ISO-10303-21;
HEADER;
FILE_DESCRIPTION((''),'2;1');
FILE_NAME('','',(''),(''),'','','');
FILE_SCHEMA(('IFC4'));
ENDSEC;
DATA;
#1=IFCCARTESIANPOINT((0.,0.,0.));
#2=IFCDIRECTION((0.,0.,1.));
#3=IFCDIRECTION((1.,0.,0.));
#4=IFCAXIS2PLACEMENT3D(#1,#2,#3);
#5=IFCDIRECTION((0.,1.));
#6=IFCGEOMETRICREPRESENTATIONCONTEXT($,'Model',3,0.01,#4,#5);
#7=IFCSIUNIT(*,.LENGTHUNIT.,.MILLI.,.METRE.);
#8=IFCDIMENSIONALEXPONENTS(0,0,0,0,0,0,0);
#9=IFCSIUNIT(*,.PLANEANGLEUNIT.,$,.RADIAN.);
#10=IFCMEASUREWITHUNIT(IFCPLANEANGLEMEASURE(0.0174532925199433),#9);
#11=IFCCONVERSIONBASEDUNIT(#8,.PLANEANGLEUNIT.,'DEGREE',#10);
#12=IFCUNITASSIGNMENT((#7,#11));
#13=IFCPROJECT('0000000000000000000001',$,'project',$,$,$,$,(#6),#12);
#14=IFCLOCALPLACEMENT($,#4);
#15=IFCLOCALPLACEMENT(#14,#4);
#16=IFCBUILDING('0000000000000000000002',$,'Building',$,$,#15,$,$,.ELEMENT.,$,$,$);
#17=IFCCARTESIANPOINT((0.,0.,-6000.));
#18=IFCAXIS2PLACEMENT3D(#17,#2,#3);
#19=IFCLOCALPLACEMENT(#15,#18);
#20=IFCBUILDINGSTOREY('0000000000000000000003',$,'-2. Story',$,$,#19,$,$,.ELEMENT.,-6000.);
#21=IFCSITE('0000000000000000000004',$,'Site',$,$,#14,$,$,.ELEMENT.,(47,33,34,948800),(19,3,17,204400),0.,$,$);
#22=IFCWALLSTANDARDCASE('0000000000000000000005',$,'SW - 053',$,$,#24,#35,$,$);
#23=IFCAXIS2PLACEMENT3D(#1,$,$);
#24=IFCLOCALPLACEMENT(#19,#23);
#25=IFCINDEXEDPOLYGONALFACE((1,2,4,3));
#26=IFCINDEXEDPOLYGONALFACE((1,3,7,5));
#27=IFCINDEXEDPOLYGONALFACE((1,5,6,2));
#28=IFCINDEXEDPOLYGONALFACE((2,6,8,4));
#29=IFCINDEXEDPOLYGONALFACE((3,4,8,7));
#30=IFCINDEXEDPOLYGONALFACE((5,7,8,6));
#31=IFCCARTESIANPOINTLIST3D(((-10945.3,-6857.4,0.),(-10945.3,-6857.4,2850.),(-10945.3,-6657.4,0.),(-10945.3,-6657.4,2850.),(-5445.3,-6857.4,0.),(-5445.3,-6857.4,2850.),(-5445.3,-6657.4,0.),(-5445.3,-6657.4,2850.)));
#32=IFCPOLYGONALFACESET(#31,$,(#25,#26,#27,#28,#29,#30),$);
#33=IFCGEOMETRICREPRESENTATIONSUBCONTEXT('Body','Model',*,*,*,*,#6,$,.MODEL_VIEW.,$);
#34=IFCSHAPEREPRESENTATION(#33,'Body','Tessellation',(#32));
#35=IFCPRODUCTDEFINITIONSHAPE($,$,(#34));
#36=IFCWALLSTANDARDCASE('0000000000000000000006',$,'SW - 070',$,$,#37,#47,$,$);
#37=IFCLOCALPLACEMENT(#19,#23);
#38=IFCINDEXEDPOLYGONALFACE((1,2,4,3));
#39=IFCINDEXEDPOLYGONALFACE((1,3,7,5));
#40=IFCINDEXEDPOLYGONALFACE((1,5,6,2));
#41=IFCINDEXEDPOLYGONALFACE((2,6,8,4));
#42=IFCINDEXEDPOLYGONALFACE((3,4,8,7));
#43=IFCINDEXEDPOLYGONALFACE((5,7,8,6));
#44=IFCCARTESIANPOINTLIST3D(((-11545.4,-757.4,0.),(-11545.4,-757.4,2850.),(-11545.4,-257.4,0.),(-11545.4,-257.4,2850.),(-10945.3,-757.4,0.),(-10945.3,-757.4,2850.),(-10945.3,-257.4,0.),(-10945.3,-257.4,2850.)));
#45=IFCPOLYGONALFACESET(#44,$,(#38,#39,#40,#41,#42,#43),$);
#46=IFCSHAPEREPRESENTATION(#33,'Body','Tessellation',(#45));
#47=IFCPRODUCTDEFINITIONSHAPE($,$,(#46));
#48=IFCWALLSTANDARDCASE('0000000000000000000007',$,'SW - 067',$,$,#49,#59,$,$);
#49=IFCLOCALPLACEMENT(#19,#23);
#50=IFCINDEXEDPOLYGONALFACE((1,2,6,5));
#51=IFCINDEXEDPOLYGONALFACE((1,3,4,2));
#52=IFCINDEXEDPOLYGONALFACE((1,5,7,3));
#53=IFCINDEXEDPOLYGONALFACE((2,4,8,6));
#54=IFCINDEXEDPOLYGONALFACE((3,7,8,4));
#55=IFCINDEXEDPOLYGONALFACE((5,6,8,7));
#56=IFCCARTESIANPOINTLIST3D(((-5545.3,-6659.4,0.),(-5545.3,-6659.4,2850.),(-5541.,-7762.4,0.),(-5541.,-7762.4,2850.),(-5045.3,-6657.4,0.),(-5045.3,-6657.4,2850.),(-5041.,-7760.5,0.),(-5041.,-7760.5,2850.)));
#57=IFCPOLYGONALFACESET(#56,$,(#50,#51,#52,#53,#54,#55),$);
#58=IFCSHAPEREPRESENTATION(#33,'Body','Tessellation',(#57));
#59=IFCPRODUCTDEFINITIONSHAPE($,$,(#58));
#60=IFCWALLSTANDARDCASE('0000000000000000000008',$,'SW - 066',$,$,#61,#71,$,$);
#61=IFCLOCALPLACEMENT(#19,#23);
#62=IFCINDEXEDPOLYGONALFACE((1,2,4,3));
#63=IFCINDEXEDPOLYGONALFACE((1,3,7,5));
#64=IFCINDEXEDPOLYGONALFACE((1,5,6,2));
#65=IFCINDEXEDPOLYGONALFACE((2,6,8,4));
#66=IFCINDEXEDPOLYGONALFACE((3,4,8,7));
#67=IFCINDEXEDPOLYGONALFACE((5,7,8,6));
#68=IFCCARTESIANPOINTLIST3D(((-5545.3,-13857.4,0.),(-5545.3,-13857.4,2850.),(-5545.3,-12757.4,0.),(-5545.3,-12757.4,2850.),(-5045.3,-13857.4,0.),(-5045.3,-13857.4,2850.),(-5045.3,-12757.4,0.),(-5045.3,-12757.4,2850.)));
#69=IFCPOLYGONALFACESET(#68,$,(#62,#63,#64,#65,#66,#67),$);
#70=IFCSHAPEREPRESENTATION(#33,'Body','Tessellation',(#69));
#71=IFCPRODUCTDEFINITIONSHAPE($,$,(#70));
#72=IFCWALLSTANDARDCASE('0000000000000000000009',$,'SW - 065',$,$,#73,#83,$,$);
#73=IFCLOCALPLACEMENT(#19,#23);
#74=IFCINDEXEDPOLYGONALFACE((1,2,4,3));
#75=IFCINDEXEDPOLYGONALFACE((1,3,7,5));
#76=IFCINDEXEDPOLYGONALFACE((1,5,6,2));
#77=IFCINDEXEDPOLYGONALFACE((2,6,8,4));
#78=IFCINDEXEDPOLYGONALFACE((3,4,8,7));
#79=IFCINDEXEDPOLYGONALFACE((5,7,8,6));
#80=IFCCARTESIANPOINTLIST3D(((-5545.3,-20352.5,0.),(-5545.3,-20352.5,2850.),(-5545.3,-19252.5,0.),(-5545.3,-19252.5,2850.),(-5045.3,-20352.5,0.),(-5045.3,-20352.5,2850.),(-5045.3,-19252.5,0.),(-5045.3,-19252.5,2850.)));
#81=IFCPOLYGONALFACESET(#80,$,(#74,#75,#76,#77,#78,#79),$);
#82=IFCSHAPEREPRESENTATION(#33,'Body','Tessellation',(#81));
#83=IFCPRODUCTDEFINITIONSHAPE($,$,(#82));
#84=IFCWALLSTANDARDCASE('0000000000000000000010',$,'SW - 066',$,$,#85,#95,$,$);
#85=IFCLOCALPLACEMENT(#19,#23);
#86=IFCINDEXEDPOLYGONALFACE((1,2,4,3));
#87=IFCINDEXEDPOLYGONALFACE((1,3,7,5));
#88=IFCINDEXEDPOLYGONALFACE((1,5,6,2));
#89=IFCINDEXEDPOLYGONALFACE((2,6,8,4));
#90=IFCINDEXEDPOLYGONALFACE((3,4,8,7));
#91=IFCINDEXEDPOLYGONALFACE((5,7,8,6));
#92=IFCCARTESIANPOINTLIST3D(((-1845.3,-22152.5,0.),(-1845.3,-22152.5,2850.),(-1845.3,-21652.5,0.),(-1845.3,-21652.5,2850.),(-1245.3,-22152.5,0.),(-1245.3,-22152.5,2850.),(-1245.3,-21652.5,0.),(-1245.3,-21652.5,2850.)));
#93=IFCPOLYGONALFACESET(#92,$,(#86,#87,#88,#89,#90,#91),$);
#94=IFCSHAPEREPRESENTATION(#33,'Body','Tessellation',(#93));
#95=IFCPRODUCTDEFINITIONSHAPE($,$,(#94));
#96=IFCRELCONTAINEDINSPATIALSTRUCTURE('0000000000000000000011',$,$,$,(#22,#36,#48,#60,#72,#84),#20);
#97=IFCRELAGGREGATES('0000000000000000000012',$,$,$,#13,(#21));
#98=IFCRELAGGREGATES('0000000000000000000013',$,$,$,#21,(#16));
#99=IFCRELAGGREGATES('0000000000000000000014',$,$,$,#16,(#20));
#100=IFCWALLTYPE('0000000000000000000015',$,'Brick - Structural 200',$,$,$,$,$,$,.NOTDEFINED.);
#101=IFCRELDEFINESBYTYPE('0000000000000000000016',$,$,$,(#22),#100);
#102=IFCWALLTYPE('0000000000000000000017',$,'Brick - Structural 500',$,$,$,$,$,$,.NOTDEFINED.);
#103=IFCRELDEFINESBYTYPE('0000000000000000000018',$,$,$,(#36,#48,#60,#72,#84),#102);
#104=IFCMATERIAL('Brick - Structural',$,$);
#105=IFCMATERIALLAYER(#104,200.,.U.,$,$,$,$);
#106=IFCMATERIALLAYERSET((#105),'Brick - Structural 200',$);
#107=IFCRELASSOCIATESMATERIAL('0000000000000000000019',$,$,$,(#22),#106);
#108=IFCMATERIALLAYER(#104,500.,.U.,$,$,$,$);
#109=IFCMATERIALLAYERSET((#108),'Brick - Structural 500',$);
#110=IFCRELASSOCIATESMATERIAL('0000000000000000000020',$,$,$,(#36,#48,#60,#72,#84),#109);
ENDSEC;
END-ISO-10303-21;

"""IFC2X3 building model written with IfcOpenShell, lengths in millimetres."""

from ifc_helpers import new_model, entity, si_unit, converted_unit, direction, frame, origin_with_axes, place, context, subcontext, project, spatial, polyline, outline, extrude, material, layer, layer_set, layer_usage, type_object, element, save


model = new_model("IFC2X3")

# Units and contexts
model_context = context("Model", 3, precision=0.01, world=origin_with_axes(), true_north=direction((0.0, 1.0)))
body_context = subcontext(model_context, "Body", "Model", "MODEL_VIEW")
ifc_project = project(units=[si_unit("LENGTHUNIT", "METRE", prefix="MILLI"), converted_unit("PLANEANGLEUNIT", "DEGREE", entity("IfcPlaneAngleMeasure", 0.0174532925199433), si_unit("PLANEANGLEUNIT", "RADIAN"), dimensions=[0, 0, 0, 0, 0, 0, 0])], contexts=[model_context])

# Site, building, storey
site_placement = place(None, origin_with_axes())
site = spatial("IfcSite", under=ifc_project, at=site_placement, Name="Site", CompositionType="ELEMENT", RefLatitude=(47, 33, 34, 948800), RefLongitude=(19, 3, 17, 204400), RefElevation=0.0)
building_placement = place(site_placement, origin_with_axes())
building = spatial("IfcBuilding", under=site, at=building_placement, Name="Building", CompositionType="ELEMENT")
storey_placement = place(building_placement, frame((0.0, 0.0, -6000.0), z_axis=(0.0, 0.0, 1.0), x_axis=(1.0, 0.0, 0.0)))
storey = spatial("IfcBuildingStorey", under=building, at=storey_placement, Name="-2. Story", CompositionType="ELEMENT", Elevation=-6000.0)

# Shared definitions
ifc_material_1 = material(Name="Brick - Structural")

# Shared definitions
ifc_layer_1 = layer(ifc_material_1, 200.0, ventilated="UNKNOWN")
ifc_layer_set_1 = layer_set([ifc_layer_1], Name="Brick - Structural 200")
wall_type_1 = type_object("IfcWallType", Name="Brick - Structural 200", PredefinedType="NOTDEFINED")

# Walls
ifc_layer_usage_1 = layer_usage(ifc_layer_set_1, "AXIS2", "NEGATIVE", 0.0)
wall_1_placement = place(storey_placement, frame((-10945.3, -6657.4, 0.0), z_axis=(0.0, 0.0, 1.0), x_axis=(1.0, 0.0, 0.0)))
element("IfcWallStandardCase", 1, at=wall_1_placement, inside=storey, type_object=wall_type_1, material=ifc_layer_usage_1, Name="SW - 053", context=body_context, shape_type="SweptSolid", body=[
    extrude(outline(polyline([(0.0, -200.0), (5500.0, -200.0), (5500.0, 0.0), (0.0, 0.0), (0.0, -200.0)])), origin_with_axes(), (0.0, 0.0, 1.0), 2850.0),
])
ifc_layer_2 = layer(ifc_material_1, 500.0, ventilated="UNKNOWN")
ifc_layer_set_2 = layer_set([ifc_layer_2], Name="Brick - Structural 500")
ifc_layer_usage_2 = layer_usage(ifc_layer_set_2, "AXIS2", "POSITIVE", 0.0)
wall_type_2 = type_object("IfcWallType", Name="Brick - Structural 500", PredefinedType="NOTDEFINED")
wall_2_placement = place(storey_placement, frame((-10945.3, -257.4, 0.0), z_axis=(0.0, 0.0, 1.0), x_axis=(-1.0, 0.0, 0.0)))
element("IfcWallStandardCase", 2, at=wall_2_placement, inside=storey, type_object=wall_type_2, material=ifc_layer_usage_2, Name="SW - 070", context=body_context, shape_type="SweptSolid", body=[
    extrude(outline(polyline([(0.0, 0.0), (600.1, 0.0), (600.1, 500.0), (0.0, 500.0), (0.0, 0.0)])), origin_with_axes(), (0.0, 0.0, 1.0), 2850.0),
])
ifc_layer_usage_3 = layer_usage(ifc_layer_set_2, "AXIS2", "POSITIVE", 0.0)
wall_3_placement = place(storey_placement, frame((-5041.0, -7760.5, 0.0), z_axis=(0.0, 0.0, 1.0), x_axis=(-0.00392, 0.999992, 0.0)))
element("IfcWallStandardCase", 3, at=wall_3_placement, inside=storey, type_object=wall_type_2, material=ifc_layer_usage_3, Name="SW - 067", context=body_context, shape_type="SweptSolid", body=[
    extrude(outline(polyline([(0.0, 0.0), (1103.1, 0.0), (1103.1, 500.0), (0.0, 500.0), (0.0, 0.0)])), origin_with_axes(), (0.0, 0.0, 1.0), 2850.0),
])
ifc_layer_usage_4 = layer_usage(ifc_layer_set_2, "AXIS2", "POSITIVE", 0.0)
wall_4_placement = place(storey_placement, frame((-5045.3, -13857.4, 0.0), z_axis=(0.0, 0.0, 1.0), x_axis=(0.0, 1.0, 0.0)))
element("IfcWallStandardCase", 4, at=wall_4_placement, inside=storey, type_object=wall_type_2, material=ifc_layer_usage_4, Name="SW - 066", context=body_context, shape_type="SweptSolid", body=[
    extrude(outline(polyline([(0.0, 0.0), (1100.0, 0.0), (1100.0, 500.0), (0.0, 500.0), (0.0, 0.0)])), origin_with_axes(), (0.0, 0.0, 1.0), 2850.0),
])
ifc_layer_usage_5 = layer_usage(ifc_layer_set_2, "AXIS2", "POSITIVE", 0.0)
wall_5_placement = place(storey_placement, frame((-5045.3, -20352.5, 0.0), z_axis=(0.0, 0.0, 1.0), x_axis=(0.0, 1.0, 0.0)))
element("IfcWallStandardCase", 5, at=wall_5_placement, inside=storey, type_object=wall_type_2, material=ifc_layer_usage_5, Name="SW - 065", context=body_context, shape_type="SweptSolid", body=[
    extrude(outline(polyline([(0.0, 0.0), (1100.0, 0.0), (1100.0, 500.0), (0.0, 500.0), (0.0, 0.0)])), origin_with_axes(), (0.0, 0.0, 1.0), 2850.0),
])
ifc_layer_usage_6 = layer_usage(ifc_layer_set_2, "AXIS2", "POSITIVE", 0.0)
wall_6_placement = place(storey_placement, frame((-1245.3, -21652.5, 0.0), z_axis=(0.0, 0.0, 1.0), x_axis=(-1.0, 0.0, 0.0)))
element("IfcWallStandardCase", 6, at=wall_6_placement, inside=storey, type_object=wall_type_2, material=ifc_layer_usage_6, Name="SW - 066", context=body_context, shape_type="SweptSolid", body=[
    extrude(outline(polyline([(0.0, 0.0), (600.0, 0.0), (600.0, 500.0), (0.0, 500.0), (0.0, 0.0)])), origin_with_axes(), (0.0, 0.0, 1.0), 2850.0),
])

save(model, "model.ifc")
